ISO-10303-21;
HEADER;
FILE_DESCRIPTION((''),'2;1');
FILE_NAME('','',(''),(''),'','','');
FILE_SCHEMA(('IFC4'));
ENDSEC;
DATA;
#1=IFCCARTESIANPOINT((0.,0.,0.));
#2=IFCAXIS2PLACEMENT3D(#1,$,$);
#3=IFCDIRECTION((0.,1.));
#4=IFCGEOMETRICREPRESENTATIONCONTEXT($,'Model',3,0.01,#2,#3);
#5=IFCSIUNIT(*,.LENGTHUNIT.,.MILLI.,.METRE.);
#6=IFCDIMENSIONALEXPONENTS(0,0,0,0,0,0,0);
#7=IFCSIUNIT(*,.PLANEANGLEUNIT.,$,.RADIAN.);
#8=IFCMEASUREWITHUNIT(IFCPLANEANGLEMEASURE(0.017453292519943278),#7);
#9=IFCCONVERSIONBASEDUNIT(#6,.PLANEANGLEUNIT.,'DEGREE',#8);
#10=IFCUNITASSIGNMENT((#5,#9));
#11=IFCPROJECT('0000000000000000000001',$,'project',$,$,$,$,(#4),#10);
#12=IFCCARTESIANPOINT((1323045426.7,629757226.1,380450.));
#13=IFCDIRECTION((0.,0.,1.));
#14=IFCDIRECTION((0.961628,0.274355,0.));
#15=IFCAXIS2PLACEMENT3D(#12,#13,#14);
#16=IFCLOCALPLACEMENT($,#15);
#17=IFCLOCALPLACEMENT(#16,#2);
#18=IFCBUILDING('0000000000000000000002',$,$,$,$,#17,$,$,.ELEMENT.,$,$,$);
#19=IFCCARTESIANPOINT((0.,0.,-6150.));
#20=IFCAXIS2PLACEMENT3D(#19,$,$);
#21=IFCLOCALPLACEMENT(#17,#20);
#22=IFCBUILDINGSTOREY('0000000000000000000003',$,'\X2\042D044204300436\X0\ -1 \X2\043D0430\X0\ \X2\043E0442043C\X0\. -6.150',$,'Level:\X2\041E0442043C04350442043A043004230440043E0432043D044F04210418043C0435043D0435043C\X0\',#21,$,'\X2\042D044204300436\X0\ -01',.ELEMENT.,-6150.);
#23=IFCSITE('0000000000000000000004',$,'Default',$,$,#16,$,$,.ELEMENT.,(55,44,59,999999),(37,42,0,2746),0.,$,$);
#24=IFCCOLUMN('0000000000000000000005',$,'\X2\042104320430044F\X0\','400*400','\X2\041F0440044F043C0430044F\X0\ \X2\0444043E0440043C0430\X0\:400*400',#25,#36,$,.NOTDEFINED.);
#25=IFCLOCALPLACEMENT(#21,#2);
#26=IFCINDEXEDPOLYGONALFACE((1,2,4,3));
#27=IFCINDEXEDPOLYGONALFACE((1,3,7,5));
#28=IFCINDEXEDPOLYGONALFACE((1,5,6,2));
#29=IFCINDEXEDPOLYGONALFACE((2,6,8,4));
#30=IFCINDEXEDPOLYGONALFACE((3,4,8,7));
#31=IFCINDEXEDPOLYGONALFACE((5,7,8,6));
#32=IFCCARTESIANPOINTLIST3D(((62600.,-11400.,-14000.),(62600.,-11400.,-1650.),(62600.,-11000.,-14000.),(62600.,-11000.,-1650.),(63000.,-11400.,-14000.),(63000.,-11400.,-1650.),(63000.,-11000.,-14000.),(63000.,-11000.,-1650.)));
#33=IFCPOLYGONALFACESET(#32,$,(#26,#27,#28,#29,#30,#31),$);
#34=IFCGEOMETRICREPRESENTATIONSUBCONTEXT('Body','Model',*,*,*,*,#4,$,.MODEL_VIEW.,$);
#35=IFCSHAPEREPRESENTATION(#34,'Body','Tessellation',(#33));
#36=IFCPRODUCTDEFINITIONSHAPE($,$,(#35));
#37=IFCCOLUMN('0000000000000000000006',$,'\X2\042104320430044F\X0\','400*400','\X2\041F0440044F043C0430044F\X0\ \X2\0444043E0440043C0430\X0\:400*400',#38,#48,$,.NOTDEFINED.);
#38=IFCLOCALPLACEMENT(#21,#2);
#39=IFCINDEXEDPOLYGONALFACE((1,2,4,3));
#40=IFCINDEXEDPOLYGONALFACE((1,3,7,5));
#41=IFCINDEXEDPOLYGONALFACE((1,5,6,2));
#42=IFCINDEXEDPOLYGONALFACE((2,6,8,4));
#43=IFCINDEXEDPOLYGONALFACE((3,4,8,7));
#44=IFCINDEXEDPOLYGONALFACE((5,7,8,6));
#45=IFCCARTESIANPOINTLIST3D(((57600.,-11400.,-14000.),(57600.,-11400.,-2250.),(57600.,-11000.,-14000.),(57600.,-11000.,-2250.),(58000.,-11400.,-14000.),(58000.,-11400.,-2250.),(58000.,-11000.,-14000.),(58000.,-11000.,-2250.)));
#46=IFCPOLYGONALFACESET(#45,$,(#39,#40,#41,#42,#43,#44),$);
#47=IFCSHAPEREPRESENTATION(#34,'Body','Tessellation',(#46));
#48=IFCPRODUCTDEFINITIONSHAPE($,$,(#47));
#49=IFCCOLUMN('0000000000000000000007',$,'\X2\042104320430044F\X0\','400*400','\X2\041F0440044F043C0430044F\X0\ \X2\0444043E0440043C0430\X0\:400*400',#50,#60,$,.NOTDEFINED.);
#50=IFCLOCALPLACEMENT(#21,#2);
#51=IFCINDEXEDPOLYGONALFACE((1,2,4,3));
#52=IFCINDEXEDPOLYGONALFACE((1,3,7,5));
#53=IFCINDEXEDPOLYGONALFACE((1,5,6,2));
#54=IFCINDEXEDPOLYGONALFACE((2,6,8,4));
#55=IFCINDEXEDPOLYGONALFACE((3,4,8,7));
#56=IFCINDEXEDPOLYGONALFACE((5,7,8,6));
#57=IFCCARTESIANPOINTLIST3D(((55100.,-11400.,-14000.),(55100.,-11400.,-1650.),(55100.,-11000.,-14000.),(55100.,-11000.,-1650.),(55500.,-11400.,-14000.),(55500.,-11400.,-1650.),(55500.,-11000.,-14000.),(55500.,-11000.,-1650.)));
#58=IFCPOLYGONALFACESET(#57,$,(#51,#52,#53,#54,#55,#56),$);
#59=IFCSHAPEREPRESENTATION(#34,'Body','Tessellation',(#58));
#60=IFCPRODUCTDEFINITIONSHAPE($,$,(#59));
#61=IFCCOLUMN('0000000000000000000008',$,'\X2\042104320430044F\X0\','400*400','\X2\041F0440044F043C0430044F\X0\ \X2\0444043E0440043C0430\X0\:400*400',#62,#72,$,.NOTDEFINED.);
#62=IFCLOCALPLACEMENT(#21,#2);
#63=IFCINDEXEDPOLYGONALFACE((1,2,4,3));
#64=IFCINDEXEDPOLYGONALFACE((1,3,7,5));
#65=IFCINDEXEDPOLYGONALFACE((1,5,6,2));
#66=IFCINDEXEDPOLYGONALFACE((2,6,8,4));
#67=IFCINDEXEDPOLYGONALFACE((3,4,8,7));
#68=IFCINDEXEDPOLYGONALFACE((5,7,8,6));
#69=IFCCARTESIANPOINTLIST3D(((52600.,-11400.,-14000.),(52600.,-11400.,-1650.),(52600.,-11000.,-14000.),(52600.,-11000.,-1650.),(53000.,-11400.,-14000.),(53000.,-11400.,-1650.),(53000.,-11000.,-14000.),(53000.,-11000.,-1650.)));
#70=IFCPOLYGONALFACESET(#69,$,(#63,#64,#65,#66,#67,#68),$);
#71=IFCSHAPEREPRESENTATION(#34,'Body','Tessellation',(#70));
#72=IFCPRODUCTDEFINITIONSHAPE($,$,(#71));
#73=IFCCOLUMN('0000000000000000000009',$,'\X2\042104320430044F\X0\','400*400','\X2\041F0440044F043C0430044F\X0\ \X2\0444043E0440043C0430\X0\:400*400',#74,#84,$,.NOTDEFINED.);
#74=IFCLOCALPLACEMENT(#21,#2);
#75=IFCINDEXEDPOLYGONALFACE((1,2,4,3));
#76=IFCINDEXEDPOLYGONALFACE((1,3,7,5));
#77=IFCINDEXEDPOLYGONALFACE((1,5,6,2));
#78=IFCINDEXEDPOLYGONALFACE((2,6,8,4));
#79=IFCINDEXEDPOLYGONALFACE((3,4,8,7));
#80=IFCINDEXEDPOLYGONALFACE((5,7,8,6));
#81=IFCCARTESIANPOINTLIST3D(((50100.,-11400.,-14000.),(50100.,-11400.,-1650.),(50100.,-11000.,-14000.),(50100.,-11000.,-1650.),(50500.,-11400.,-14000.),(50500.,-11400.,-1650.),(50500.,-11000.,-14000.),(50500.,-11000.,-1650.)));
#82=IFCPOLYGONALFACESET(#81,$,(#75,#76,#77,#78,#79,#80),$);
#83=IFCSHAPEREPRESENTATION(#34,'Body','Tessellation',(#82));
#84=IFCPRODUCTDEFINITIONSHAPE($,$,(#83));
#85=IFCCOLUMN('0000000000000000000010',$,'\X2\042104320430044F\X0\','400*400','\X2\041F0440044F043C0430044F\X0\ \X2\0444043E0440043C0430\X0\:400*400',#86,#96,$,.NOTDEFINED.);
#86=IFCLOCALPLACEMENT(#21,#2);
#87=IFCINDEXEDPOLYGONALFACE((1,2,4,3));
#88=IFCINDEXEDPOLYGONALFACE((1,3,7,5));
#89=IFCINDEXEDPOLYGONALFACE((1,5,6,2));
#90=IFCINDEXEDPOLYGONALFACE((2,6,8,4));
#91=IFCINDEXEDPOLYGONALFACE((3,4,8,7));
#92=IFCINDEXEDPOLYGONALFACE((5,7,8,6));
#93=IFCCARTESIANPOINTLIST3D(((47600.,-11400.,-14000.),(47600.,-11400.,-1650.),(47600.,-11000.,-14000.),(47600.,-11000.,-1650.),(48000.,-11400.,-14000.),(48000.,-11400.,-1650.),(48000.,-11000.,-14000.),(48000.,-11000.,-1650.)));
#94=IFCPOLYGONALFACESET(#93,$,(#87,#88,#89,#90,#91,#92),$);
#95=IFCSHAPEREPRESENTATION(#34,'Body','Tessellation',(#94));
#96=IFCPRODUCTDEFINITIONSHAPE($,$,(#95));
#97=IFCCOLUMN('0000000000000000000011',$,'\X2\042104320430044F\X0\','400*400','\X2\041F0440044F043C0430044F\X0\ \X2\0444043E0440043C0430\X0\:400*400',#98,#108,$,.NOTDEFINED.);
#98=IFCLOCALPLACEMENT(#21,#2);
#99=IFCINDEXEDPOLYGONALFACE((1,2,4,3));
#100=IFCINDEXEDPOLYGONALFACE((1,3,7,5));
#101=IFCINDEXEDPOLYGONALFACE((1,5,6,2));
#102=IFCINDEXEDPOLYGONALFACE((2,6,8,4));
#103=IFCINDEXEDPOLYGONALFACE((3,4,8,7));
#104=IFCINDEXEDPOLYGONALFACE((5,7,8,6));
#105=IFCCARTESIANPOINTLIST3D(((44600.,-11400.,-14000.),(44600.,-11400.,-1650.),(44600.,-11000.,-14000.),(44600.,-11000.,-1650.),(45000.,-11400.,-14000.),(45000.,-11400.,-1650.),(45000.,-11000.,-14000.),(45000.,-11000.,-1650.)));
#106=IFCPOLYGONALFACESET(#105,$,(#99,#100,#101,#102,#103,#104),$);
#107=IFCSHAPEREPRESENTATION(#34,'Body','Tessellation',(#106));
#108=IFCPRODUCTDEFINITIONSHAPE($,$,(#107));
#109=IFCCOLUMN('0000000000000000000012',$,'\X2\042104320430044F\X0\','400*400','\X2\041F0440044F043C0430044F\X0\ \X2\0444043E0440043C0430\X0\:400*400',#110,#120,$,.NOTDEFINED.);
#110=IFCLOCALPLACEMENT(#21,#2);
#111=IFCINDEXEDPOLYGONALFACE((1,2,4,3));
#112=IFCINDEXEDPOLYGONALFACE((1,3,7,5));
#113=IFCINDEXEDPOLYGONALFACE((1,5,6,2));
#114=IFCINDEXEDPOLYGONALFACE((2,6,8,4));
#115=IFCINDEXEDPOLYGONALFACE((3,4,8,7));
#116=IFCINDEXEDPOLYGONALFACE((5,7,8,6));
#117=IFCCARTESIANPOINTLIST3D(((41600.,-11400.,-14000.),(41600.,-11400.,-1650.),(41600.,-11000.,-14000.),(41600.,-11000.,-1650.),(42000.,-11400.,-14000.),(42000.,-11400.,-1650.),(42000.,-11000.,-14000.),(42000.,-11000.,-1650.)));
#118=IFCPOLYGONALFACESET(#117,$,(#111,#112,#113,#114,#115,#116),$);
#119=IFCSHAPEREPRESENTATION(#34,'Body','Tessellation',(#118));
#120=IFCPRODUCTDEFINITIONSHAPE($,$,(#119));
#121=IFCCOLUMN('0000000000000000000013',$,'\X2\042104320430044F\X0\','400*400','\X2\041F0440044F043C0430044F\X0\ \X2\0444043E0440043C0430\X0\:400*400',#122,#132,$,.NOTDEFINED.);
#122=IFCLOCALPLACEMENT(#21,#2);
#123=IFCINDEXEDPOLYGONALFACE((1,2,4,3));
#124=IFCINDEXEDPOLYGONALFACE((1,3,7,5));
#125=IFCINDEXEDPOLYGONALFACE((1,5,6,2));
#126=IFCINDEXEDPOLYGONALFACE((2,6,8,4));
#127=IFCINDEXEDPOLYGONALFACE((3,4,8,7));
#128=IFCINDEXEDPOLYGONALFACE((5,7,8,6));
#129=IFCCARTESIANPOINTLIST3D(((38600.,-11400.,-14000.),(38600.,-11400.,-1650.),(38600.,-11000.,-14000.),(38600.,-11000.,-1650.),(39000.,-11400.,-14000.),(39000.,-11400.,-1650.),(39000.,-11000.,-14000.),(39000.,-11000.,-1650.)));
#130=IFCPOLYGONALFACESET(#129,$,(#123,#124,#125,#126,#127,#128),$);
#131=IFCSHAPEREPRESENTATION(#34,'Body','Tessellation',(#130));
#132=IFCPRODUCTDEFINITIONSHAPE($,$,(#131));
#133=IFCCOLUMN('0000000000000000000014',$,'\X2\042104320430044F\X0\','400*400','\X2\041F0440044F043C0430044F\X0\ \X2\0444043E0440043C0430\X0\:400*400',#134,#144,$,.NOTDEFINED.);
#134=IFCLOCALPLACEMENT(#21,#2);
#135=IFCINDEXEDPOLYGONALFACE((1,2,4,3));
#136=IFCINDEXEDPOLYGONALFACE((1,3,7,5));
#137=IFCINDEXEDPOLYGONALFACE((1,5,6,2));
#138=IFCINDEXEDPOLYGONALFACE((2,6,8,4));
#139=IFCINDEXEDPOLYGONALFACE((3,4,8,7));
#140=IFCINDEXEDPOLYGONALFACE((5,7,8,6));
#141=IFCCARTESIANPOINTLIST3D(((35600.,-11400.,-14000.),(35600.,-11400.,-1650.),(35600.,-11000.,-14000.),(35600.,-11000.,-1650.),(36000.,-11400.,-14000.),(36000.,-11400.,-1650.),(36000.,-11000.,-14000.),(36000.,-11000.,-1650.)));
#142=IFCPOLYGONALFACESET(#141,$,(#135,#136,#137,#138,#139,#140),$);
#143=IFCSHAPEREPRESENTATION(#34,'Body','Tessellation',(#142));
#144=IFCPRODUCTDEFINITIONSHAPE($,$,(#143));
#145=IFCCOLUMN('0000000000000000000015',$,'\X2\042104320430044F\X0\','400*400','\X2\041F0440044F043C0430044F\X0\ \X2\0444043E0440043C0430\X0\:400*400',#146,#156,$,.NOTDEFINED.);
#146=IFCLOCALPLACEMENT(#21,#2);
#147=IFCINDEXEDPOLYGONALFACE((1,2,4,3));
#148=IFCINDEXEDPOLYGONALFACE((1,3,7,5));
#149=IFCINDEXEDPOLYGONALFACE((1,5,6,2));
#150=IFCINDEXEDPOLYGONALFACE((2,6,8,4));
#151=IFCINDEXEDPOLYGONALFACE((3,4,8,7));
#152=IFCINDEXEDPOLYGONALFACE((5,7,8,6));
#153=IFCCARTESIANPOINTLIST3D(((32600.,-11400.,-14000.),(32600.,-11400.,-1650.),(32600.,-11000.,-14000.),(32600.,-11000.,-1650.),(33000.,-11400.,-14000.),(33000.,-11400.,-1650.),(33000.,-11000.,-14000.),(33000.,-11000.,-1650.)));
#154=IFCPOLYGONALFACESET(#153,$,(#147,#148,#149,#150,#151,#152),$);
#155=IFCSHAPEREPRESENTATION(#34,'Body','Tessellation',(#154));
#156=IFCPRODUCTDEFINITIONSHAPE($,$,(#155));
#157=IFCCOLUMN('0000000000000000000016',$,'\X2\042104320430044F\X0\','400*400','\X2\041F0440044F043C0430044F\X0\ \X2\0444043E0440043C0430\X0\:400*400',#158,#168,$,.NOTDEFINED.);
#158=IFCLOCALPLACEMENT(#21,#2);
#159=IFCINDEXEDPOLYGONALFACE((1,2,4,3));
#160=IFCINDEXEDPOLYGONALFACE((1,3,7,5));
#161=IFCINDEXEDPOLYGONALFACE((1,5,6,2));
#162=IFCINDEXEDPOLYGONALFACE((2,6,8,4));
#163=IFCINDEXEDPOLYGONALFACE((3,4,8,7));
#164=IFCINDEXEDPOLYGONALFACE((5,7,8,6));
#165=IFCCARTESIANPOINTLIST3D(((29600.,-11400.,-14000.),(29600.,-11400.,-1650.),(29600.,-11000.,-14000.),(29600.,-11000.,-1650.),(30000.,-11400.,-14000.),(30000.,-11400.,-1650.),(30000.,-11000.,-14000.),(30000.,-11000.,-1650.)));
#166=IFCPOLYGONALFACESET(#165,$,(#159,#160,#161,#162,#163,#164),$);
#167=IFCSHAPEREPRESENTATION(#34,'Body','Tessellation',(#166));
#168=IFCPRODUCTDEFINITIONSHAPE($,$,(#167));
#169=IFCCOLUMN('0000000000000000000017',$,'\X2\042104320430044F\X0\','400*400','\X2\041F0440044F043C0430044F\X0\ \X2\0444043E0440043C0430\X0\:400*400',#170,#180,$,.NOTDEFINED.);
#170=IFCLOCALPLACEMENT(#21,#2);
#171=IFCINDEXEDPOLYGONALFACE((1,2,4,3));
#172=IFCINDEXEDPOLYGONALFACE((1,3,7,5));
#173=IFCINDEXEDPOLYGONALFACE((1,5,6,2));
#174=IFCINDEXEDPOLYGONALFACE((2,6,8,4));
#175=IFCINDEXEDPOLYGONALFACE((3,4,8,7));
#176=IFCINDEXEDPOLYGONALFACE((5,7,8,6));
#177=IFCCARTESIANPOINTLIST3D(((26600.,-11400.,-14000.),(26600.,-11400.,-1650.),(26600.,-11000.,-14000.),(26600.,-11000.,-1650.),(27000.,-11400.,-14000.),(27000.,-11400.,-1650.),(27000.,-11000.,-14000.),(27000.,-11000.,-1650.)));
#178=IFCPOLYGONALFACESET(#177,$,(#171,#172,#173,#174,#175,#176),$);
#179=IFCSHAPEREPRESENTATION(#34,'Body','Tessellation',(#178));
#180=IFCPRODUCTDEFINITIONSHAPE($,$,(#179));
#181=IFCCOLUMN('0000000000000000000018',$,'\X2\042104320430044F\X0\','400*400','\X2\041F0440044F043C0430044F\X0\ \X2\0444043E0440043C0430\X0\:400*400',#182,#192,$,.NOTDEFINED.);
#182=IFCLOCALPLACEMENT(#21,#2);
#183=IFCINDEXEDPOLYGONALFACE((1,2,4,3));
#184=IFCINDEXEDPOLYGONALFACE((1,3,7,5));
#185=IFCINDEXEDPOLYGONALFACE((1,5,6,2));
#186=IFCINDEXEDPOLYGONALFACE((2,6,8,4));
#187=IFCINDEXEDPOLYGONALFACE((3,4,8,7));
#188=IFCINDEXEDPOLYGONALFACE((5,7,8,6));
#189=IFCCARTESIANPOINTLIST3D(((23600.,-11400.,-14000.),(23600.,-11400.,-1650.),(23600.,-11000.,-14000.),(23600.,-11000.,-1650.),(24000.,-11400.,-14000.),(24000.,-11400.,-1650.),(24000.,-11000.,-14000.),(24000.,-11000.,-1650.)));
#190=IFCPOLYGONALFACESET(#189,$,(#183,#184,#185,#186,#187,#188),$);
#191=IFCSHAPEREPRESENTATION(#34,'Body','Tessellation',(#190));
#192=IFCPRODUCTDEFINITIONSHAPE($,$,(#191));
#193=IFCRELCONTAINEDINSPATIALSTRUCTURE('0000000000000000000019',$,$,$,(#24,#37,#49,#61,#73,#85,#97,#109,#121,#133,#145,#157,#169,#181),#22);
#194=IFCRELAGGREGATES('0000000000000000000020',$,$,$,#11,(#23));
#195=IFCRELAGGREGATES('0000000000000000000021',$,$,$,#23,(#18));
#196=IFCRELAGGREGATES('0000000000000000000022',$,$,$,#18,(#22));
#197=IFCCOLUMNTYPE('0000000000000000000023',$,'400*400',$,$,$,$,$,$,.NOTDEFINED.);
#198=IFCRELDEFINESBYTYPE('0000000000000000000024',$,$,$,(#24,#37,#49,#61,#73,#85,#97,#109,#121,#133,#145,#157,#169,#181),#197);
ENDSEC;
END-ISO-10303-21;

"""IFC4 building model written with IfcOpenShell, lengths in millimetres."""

from ifc_helpers import new_model, entity, si_unit, converted_unit, direction, frame, origin, place, context, subcontext, project, spatial, indexed_curve, outline, extrude, type_object, element, save


model = new_model("IFC4")

# Units and contexts
model_context = context("Model", 3, precision=0.01, world=origin(), true_north=direction((0.0, 1.0)))
body_context = subcontext(model_context, "Body", "Model", "MODEL_VIEW")
ifc_project = project(units=[si_unit("LENGTHUNIT", "METRE", prefix="MILLI"), converted_unit("PLANEANGLEUNIT", "DEGREE", entity("IfcPlaneAngleMeasure", 0.017453292519943278), si_unit("PLANEANGLEUNIT", "RADIAN"), dimensions=[0, 0, 0, 0, 0, 0, 0])], contexts=[model_context])

# Site, building, storey
site_placement = place(None, frame((1323045426.7, 629757226.1, 380450.0), z_axis=(0.0, 0.0, 1.0), x_axis=(0.961628, 0.274355, 0.0)))
site = spatial("IfcSite", under=ifc_project, at=site_placement, Name="Default", CompositionType="ELEMENT", RefLatitude=(55, 44, 59, 999999), RefLongitude=(37, 42, 0, 2746), RefElevation=0.0)
building_placement = place(site_placement, origin())
building = spatial("IfcBuilding", under=site, at=building_placement, CompositionType="ELEMENT")
storey_placement = place(building_placement, frame((0.0, 0.0, -6150.0)))
storey = spatial("IfcBuildingStorey", under=building, at=storey_placement, Name="Этаж -1 на отм. -6.150", ObjectType="Level:ОтметкаУровняСИменем", LongName="Этаж -01", CompositionType="ELEMENT", Elevation=-6150.0)

# Columns
column_type = type_object("IfcColumnType", Name="400*400", PredefinedType="NOTDEFINED")
column_1_placement = place(storey_placement, origin())
element("IfcColumn", 1, at=column_1_placement, inside=storey, type_object=column_type, Name="Свая", Description="400*400", ObjectType="Прямая форма:400*400", PredefinedType="NOTDEFINED", context=body_context, shape_type="SweptSolid", body=[
    extrude(outline(indexed_curve([(-200.0, -200.0), (200.0, -200.0), (200.0, 200.0), (-200.0, 200.0), (-200.0, -200.0)], self_intersect=False)), frame((62800.0, -11200.0, -14000.0), z_axis=(0.0, 0.0, 1.0), x_axis=(0.0, 1.0, 0.0)), (0.0, 0.0, 1.0), 12350.0),
])
column_2_placement = place(storey_placement, origin())
element("IfcColumn", 2, at=column_2_placement, inside=storey, type_object=column_type, Name="Свая", Description="400*400", ObjectType="Прямая форма:400*400", PredefinedType="NOTDEFINED", context=body_context, shape_type="SweptSolid", body=[
    extrude(outline(indexed_curve([(-200.0, -200.0), (200.0, -200.0), (200.0, 200.0), (-200.0, 200.0), (-200.0, -200.0)], self_intersect=False)), frame((57800.0, -11200.0, -14000.0), z_axis=(0.0, 0.0, 1.0), x_axis=(0.0, 1.0, 0.0)), (0.0, 0.0, 1.0), 11750.0),
])
column_3_placement = place(storey_placement, origin())
element("IfcColumn", 3, at=column_3_placement, inside=storey, type_object=column_type, Name="Свая", Description="400*400", ObjectType="Прямая форма:400*400", PredefinedType="NOTDEFINED", context=body_context, shape_type="SweptSolid", body=[
    extrude(outline(indexed_curve([(-200.0, -200.0), (200.0, -200.0), (200.0, 200.0), (-200.0, 200.0), (-200.0, -200.0)], self_intersect=False)), frame((55300.0, -11200.0, -14000.0), z_axis=(0.0, 0.0, 1.0), x_axis=(0.0, 1.0, 0.0)), (0.0, 0.0, 1.0), 12350.0),
])
column_4_placement = place(storey_placement, origin())
element("IfcColumn", 4, at=column_4_placement, inside=storey, type_object=column_type, Name="Свая", Description="400*400", ObjectType="Прямая форма:400*400", PredefinedType="NOTDEFINED", context=body_context, shape_type="SweptSolid", body=[
    extrude(outline(indexed_curve([(-200.0, -200.0), (200.0, -200.0), (200.0, 200.0), (-200.0, 200.0), (-200.0, -200.0)], self_intersect=False)), frame((52800.0, -11200.0, -14000.0), z_axis=(0.0, 0.0, 1.0), x_axis=(0.0, 1.0, 0.0)), (0.0, 0.0, 1.0), 12350.0),
])
column_5_placement = place(storey_placement, origin())
element("IfcColumn", 5, at=column_5_placement, inside=storey, type_object=column_type, Name="Свая", Description="400*400", ObjectType="Прямая форма:400*400", PredefinedType="NOTDEFINED", context=body_context, shape_type="SweptSolid", body=[
    extrude(outline(indexed_curve([(-200.0, -200.0), (200.0, -200.0), (200.0, 200.0), (-200.0, 200.0), (-200.0, -200.0)], self_intersect=False)), frame((50300.0, -11200.0, -14000.0), z_axis=(0.0, 0.0, 1.0), x_axis=(0.0, 1.0, 0.0)), (0.0, 0.0, 1.0), 12350.0),
])
column_6_placement = place(storey_placement, origin())
element("IfcColumn", 6, at=column_6_placement, inside=storey, type_object=column_type, Name="Свая", Description="400*400", ObjectType="Прямая форма:400*400", PredefinedType="NOTDEFINED", context=body_context, shape_type="SweptSolid", body=[
    extrude(outline(indexed_curve([(-200.0, -200.0), (200.0, -200.0), (200.0, 200.0), (-200.0, 200.0), (-200.0, -200.0)], self_intersect=False)), frame((47800.0, -11200.0, -14000.0), z_axis=(0.0, 0.0, 1.0), x_axis=(0.0, 1.0, 0.0)), (0.0, 0.0, 1.0), 12350.0),
])
column_7_placement = place(storey_placement, origin())
element("IfcColumn", 7, at=column_7_placement, inside=storey, type_object=column_type, Name="Свая", Description="400*400", ObjectType="Прямая форма:400*400", PredefinedType="NOTDEFINED", context=body_context, shape_type="SweptSolid", body=[
    extrude(outline(indexed_curve([(-200.0, -200.0), (200.0, -200.0), (200.0, 200.0), (-200.0, 200.0), (-200.0, -200.0)], self_intersect=False)), frame((44800.0, -11200.0, -14000.0), z_axis=(0.0, 0.0, 1.0), x_axis=(0.0, 1.0, 0.0)), (0.0, 0.0, 1.0), 12350.0),
])
column_8_placement = place(storey_placement, origin())
element("IfcColumn", 8, at=column_8_placement, inside=storey, type_object=column_type, Name="Свая", Description="400*400", ObjectType="Прямая форма:400*400", PredefinedType="NOTDEFINED", context=body_context, shape_type="SweptSolid", body=[
    extrude(outline(indexed_curve([(-200.0, -200.0), (200.0, -200.0), (200.0, 200.0), (-200.0, 200.0), (-200.0, -200.0)], self_intersect=False)), frame((41800.0, -11200.0, -14000.0), z_axis=(0.0, 0.0, 1.0), x_axis=(0.0, 1.0, 0.0)), (0.0, 0.0, 1.0), 12350.0),
])
column_9_placement = place(storey_placement, origin())
element("IfcColumn", 9, at=column_9_placement, inside=storey, type_object=column_type, Name="Свая", Description="400*400", ObjectType="Прямая форма:400*400", PredefinedType="NOTDEFINED", context=body_context, shape_type="SweptSolid", body=[
    extrude(outline(indexed_curve([(-200.0, -200.0), (200.0, -200.0), (200.0, 200.0), (-200.0, 200.0), (-200.0, -200.0)], self_intersect=False)), frame((38800.0, -11200.0, -14000.0), z_axis=(0.0, 0.0, 1.0), x_axis=(0.0, 1.0, 0.0)), (0.0, 0.0, 1.0), 12350.0),
])
column_10_placement = place(storey_placement, origin())
element("IfcColumn", 10, at=column_10_placement, inside=storey, type_object=column_type, Name="Свая", Description="400*400", ObjectType="Прямая форма:400*400", PredefinedType="NOTDEFINED", context=body_context, shape_type="SweptSolid", body=[
    extrude(outline(indexed_curve([(-200.0, -200.0), (200.0, -200.0), (200.0, 200.0), (-200.0, 200.0), (-200.0, -200.0)], self_intersect=False)), frame((35800.0, -11200.0, -14000.0), z_axis=(0.0, 0.0, 1.0), x_axis=(0.0, 1.0, 0.0)), (0.0, 0.0, 1.0), 12350.0),
])
column_11_placement = place(storey_placement, origin())
element("IfcColumn", 11, at=column_11_placement, inside=storey, type_object=column_type, Name="Свая", Description="400*400", ObjectType="Прямая форма:400*400", PredefinedType="NOTDEFINED", context=body_context, shape_type="SweptSolid", body=[
    extrude(outline(indexed_curve([(-200.0, -200.0), (200.0, -200.0), (200.0, 200.0), (-200.0, 200.0), (-200.0, -200.0)], self_intersect=False)), frame((32800.0, -11200.0, -14000.0), z_axis=(0.0, 0.0, 1.0), x_axis=(0.0, 1.0, 0.0)), (0.0, 0.0, 1.0), 12350.0),
])
column_12_placement = place(storey_placement, origin())
element("IfcColumn", 12, at=column_12_placement, inside=storey, type_object=column_type, Name="Свая", Description="400*400", ObjectType="Прямая форма:400*400", PredefinedType="NOTDEFINED", context=body_context, shape_type="SweptSolid", body=[
    extrude(outline(indexed_curve([(-200.0, -200.0), (200.0, -200.0), (200.0, 200.0), (-200.0, 200.0), (-200.0, -200.0)], self_intersect=False)), frame((29800.0, -11200.0, -14000.0), z_axis=(0.0, 0.0, 1.0), x_axis=(0.0, 1.0, 0.0)), (0.0, 0.0, 1.0), 12350.0),
])
column_13_placement = place(storey_placement, origin())
element("IfcColumn", 13, at=column_13_placement, inside=storey, type_object=column_type, Name="Свая", Description="400*400", ObjectType="Прямая форма:400*400", PredefinedType="NOTDEFINED", context=body_context, shape_type="SweptSolid", body=[
    extrude(outline(indexed_curve([(-200.0, -200.0), (200.0, -200.0), (200.0, 200.0), (-200.0, 200.0), (-200.0, -200.0)], self_intersect=False)), frame((26800.0, -11200.0, -14000.0), z_axis=(0.0, 0.0, 1.0), x_axis=(0.0, 1.0, 0.0)), (0.0, 0.0, 1.0), 12350.0),
])
column_14_placement = place(storey_placement, origin())
element("IfcColumn", 14, at=column_14_placement, inside=storey, type_object=column_type, Name="Свая", Description="400*400", ObjectType="Прямая форма:400*400", PredefinedType="NOTDEFINED", context=body_context, shape_type="SweptSolid", body=[
    extrude(outline(indexed_curve([(-200.0, -200.0), (200.0, -200.0), (200.0, 200.0), (-200.0, 200.0), (-200.0, -200.0)], self_intersect=False)), frame((23800.0, -11200.0, -14000.0), z_axis=(0.0, 0.0, 1.0), x_axis=(0.0, 1.0, 0.0)), (0.0, 0.0, 1.0), 12350.0),
])

save(model, "model.ifc")
